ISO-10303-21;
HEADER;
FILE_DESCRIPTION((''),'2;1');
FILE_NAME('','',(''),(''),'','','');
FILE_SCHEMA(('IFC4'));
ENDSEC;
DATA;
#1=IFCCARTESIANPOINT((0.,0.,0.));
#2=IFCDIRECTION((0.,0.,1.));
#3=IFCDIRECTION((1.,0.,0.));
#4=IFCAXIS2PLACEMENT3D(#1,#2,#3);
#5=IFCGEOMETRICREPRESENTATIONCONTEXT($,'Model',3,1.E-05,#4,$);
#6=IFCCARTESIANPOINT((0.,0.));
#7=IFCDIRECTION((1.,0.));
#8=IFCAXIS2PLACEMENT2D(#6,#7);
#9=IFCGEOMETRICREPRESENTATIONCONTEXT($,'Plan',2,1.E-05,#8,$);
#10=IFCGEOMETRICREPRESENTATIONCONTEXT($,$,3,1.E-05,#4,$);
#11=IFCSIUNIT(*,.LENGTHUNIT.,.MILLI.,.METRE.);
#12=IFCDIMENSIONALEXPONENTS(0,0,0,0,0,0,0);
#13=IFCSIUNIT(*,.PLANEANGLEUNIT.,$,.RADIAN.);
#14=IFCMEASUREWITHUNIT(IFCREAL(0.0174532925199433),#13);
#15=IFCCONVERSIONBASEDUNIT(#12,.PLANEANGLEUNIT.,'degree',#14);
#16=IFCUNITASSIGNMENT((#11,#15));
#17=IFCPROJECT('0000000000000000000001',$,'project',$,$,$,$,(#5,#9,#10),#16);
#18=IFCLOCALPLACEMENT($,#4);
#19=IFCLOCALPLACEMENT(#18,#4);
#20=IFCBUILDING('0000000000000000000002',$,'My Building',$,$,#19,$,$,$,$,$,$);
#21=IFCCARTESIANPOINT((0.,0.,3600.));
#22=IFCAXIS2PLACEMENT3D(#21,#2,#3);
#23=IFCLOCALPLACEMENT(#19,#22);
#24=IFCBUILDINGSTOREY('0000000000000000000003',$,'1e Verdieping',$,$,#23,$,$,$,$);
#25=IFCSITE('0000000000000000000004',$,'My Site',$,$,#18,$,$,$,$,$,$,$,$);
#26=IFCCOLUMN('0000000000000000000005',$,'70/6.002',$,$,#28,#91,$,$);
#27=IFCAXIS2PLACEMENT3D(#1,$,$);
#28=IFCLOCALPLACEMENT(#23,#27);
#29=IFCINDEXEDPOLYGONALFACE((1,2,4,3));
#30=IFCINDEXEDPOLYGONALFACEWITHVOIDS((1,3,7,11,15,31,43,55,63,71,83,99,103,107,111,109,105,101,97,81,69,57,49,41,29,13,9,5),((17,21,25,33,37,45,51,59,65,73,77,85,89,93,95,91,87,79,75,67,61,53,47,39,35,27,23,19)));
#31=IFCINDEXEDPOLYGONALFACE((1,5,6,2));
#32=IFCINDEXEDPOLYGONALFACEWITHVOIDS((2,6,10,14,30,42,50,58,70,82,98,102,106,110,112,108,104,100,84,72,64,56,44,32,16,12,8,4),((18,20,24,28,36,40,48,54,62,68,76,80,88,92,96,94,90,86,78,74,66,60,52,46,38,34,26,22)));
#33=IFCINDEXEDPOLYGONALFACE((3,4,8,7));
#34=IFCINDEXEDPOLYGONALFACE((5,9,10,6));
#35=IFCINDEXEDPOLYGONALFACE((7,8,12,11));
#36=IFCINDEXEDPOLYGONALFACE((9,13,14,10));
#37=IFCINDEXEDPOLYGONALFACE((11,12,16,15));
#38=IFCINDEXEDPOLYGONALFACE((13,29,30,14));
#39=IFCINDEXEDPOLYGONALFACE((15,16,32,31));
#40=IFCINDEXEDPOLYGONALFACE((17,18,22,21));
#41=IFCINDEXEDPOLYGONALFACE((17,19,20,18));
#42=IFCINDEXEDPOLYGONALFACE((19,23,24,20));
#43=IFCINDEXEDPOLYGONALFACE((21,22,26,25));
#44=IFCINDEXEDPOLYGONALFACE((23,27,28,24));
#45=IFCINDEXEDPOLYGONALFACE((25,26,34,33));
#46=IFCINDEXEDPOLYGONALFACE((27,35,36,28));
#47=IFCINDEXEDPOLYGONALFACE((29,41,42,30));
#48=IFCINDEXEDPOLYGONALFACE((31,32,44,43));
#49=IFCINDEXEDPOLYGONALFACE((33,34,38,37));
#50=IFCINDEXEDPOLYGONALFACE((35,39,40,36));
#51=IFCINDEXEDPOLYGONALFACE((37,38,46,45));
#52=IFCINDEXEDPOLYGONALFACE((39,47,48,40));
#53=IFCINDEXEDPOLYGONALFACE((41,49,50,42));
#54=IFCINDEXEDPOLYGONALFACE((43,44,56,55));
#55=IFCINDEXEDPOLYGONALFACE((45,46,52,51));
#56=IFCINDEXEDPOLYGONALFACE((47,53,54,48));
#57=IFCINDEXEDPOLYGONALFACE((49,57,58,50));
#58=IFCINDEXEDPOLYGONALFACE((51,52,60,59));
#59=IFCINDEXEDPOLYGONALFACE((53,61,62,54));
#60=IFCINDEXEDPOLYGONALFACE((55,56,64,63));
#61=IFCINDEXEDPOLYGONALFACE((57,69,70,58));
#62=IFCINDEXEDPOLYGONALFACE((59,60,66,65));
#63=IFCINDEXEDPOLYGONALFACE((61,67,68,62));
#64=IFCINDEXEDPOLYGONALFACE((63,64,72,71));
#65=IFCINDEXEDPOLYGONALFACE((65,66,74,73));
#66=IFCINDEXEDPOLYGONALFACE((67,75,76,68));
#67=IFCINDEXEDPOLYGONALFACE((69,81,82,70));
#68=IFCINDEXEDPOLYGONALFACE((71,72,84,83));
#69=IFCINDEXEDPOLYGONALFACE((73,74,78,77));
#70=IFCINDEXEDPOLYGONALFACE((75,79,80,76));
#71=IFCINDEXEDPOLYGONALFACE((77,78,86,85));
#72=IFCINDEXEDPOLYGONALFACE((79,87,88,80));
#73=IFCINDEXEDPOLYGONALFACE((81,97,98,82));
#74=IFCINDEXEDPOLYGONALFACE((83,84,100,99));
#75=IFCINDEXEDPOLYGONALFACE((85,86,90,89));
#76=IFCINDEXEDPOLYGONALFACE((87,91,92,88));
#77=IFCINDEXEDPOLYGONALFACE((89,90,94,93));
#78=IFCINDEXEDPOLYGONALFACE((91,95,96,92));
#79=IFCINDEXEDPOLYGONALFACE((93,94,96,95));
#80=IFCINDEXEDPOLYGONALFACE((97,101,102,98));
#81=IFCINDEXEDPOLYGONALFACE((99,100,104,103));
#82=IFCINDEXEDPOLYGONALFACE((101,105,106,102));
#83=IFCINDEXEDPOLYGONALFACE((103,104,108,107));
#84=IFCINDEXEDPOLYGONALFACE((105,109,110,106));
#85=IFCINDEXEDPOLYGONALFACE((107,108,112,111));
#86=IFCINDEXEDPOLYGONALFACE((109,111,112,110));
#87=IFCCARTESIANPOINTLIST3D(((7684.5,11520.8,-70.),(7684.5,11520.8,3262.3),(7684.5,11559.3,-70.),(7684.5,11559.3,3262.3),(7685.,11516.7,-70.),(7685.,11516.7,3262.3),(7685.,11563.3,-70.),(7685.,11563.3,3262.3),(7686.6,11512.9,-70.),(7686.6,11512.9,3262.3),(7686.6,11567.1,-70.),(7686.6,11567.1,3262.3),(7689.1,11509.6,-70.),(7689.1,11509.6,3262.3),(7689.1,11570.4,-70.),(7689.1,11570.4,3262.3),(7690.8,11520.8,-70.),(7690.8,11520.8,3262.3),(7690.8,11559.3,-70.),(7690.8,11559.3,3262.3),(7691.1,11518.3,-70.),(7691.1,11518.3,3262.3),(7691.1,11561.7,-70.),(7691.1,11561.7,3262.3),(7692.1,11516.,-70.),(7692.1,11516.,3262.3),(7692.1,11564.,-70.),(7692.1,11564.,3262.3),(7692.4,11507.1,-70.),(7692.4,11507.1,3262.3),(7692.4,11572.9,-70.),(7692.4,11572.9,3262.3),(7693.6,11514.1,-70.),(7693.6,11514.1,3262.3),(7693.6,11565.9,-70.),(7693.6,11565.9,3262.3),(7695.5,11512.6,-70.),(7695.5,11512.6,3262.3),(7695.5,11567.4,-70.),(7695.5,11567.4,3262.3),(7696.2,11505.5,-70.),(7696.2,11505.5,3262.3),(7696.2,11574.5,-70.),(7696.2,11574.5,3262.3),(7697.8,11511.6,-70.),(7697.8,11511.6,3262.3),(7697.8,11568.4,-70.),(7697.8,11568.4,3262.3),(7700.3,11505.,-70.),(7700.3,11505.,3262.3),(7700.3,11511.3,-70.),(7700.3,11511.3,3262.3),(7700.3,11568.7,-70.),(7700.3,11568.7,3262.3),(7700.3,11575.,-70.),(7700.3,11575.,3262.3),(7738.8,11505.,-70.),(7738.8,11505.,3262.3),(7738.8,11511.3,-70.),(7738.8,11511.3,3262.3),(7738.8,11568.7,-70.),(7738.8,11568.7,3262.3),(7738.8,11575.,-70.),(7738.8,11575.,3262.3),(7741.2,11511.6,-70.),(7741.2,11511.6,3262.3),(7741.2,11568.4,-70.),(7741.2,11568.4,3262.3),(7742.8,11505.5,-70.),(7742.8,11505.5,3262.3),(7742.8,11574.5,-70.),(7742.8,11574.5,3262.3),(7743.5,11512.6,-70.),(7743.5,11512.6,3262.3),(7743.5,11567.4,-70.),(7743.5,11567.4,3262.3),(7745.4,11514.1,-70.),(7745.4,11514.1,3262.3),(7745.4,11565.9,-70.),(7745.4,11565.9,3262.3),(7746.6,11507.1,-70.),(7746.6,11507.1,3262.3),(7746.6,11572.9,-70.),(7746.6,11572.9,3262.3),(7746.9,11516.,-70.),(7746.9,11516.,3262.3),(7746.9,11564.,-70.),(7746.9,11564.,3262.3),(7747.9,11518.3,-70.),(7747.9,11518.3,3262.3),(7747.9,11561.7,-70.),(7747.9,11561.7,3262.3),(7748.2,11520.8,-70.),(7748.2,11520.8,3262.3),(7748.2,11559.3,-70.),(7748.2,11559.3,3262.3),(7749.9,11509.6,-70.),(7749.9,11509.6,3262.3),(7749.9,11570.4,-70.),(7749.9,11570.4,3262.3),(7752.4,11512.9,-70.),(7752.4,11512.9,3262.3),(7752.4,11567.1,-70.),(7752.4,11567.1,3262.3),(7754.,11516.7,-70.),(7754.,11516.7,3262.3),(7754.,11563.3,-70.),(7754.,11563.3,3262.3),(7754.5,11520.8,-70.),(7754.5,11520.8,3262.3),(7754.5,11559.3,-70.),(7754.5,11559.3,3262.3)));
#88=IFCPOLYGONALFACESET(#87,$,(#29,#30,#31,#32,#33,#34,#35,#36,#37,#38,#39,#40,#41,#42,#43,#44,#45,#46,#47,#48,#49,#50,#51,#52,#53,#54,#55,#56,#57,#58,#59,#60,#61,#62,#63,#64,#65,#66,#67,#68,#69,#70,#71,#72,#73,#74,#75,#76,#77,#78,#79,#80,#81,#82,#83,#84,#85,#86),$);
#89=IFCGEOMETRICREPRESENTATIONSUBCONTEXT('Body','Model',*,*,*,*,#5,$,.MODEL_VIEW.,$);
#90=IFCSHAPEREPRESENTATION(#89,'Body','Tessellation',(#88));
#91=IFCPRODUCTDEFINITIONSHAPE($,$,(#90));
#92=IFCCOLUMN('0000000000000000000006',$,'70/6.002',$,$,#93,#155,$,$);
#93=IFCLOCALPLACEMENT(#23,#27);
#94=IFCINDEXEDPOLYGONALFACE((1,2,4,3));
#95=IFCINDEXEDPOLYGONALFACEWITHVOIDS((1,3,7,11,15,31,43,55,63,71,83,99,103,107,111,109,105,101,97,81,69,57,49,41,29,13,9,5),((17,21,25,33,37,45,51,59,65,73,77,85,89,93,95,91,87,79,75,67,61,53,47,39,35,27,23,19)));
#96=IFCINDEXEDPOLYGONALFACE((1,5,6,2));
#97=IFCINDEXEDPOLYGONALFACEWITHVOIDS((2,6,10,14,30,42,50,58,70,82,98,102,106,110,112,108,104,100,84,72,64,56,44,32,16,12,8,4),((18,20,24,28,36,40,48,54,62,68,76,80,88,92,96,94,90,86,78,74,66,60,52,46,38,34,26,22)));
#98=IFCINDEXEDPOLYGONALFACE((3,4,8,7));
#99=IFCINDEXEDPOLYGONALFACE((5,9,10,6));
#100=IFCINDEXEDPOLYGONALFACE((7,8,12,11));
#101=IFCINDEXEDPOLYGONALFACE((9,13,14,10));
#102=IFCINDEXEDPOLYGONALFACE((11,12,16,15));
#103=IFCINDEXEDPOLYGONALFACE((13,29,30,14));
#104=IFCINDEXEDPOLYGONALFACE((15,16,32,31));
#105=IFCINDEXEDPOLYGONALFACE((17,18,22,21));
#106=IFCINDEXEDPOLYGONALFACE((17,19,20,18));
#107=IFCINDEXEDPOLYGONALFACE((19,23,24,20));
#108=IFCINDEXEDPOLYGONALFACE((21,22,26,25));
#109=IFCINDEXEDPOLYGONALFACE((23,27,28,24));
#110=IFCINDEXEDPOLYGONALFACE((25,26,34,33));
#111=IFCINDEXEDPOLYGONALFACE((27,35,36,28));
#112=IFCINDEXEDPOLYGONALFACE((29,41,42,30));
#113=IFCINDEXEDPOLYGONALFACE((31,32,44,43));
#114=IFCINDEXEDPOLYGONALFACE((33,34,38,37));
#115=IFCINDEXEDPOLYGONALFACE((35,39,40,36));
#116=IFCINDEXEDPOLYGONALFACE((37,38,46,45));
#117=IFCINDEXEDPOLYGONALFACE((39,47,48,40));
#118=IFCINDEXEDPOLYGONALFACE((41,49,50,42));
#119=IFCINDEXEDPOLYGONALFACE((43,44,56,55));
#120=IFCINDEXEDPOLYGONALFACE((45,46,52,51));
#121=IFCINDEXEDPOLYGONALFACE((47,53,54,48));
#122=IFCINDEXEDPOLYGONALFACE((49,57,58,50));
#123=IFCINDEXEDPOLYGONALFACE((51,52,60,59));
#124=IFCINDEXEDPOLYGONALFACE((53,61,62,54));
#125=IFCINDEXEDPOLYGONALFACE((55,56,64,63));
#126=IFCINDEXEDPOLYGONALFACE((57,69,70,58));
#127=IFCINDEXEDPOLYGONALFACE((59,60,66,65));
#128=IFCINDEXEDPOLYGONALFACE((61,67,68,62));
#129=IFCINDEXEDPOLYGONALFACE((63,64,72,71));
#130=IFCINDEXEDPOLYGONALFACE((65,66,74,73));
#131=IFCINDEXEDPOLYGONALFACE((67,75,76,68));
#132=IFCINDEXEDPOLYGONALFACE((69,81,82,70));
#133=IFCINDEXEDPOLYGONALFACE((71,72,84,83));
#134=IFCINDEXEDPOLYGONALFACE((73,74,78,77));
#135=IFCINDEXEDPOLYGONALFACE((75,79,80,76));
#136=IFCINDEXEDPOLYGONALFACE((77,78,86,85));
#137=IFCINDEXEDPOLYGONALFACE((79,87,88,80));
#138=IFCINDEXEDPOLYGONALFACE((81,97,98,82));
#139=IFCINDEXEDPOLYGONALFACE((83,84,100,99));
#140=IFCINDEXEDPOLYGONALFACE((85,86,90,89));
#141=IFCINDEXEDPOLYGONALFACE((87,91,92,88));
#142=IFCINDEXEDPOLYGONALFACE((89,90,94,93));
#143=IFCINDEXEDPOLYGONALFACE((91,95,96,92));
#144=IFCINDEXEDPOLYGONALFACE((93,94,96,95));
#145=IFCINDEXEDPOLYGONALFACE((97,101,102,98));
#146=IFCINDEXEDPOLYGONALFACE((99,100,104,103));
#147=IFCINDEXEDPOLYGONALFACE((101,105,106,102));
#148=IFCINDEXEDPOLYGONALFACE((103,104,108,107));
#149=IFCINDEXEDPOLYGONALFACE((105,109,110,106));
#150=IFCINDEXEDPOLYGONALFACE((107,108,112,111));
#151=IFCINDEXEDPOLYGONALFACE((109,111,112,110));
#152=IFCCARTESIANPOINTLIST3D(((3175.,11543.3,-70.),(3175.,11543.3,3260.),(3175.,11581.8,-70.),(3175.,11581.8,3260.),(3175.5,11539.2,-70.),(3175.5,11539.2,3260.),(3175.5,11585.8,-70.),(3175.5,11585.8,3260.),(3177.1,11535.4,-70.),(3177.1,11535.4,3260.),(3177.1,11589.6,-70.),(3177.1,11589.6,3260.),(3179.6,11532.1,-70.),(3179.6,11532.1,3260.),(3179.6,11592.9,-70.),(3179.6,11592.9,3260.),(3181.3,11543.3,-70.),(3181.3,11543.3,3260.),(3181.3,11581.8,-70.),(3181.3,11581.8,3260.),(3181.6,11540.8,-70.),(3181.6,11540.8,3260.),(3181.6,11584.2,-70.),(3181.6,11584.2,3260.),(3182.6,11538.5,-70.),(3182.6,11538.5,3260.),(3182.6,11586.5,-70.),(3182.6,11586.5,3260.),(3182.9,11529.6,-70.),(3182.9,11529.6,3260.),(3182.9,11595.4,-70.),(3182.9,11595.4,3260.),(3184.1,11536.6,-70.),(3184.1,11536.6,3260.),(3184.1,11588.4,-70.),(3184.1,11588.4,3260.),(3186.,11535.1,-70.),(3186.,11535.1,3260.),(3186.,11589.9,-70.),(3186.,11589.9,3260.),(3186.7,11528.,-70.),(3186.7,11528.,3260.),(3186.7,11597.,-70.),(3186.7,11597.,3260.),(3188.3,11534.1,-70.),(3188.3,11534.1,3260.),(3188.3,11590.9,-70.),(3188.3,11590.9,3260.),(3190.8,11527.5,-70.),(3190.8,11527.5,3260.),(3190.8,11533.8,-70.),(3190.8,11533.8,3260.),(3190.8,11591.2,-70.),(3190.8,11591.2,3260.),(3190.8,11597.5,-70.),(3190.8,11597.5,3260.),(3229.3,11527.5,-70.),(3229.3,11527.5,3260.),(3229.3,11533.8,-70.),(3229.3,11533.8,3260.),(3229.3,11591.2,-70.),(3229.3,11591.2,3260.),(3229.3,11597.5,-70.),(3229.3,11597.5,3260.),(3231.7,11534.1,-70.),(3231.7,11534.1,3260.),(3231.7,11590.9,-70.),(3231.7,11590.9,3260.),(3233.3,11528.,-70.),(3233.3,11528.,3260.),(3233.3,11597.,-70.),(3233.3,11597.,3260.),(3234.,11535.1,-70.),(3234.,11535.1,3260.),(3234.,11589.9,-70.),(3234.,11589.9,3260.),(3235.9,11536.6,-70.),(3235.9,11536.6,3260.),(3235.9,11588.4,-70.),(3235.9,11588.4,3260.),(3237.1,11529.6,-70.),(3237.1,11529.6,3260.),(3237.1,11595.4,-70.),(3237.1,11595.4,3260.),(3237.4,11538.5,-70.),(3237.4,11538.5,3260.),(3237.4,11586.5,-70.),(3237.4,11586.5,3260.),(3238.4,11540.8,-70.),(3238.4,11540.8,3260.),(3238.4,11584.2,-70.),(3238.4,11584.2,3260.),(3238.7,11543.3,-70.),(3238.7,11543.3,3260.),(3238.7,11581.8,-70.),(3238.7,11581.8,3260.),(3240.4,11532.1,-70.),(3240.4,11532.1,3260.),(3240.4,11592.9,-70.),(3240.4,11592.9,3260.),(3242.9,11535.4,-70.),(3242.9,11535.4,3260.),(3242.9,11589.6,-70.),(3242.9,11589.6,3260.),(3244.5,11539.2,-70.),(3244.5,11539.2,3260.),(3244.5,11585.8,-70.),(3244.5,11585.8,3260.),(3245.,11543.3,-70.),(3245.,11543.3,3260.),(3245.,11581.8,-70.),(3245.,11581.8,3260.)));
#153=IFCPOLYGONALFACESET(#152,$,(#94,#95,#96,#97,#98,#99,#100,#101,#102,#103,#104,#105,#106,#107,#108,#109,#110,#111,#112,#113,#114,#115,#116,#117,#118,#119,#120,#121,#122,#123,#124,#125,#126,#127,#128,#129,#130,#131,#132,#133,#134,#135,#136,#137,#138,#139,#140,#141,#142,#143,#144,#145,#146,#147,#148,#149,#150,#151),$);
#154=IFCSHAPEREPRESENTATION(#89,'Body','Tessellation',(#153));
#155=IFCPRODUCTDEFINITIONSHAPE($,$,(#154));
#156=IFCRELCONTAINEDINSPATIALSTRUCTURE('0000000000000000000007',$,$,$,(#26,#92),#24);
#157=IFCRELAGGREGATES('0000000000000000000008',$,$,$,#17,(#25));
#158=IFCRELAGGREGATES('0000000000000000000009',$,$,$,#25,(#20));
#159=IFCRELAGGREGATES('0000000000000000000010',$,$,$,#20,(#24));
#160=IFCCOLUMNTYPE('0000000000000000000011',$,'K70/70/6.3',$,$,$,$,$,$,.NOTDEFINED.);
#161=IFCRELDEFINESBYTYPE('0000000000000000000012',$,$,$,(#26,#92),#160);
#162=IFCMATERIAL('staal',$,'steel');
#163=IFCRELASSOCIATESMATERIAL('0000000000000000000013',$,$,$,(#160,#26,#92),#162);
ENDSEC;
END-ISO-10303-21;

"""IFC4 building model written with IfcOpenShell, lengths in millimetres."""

from ifc_helpers import new_model, entity, si_unit, converted_unit, frame, origin_with_axes, origin_2d_with_axis, place, context, subcontext, project, spatial, hollow_rectangle, extrude, material, material_profile, profile_set, profile_usage, type_object, element, save


model = new_model("IFC4")

# Units and contexts
model_context = context("Model", 3, precision=1e-05, world=origin_with_axes())
plan_context = context("Plan", 2, precision=1e-05, world=origin_2d_with_axis())
context_of_model = context(None, 3, precision=1e-05, world=origin_with_axes())
body_context = subcontext(model_context, "Body", "Model", "MODEL_VIEW")
ifc_project = project(units=[si_unit("LENGTHUNIT", "METRE", prefix="MILLI"), converted_unit("PLANEANGLEUNIT", "degree", entity("IfcReal", 0.0174532925199433), si_unit("PLANEANGLEUNIT", "RADIAN"), dimensions=[0, 0, 0, 0, 0, 0, 0])], contexts=[model_context, plan_context, context_of_model])

# Site, building, storey
site_placement = place(None, origin_with_axes())
site = spatial("IfcSite", under=ifc_project, at=site_placement, Name="My Site")
building_placement = place(site_placement, origin_with_axes())
building = spatial("IfcBuilding", under=site, at=building_placement, Name="My Building")
storey_placement = place(building_placement, frame((0.0, 0.0, 3600.0), z_axis=(0.0, 0.0, 1.0), x_axis=(1.0, 0.0, 0.0)))
storey = spatial("IfcBuildingStorey", under=building, at=storey_placement, Name="1e Verdieping")

# Columns
ifc_material_1 = material(Name="staal", Category="steel")
ifc_material_profile_1 = material_profile(ifc_material_1, hollow_rectangle(XDim=70.0, YDim=70.0, WallThickness=6.3, InnerFilletRadius=9.4, OuterFilletRadius=15.8))
ifc_profile_set_1 = profile_set([ifc_material_profile_1], Name="K70/70/6.3")
column_type_1 = type_object("IfcColumnType", Name="K70/70/6.3", PredefinedType="NOTDEFINED", material=ifc_profile_set_1)
ifc_profile_usage_1 = profile_usage(ifc_profile_set_1)
column_1_placement = place(storey_placement, frame((7719.5, 11540.0, -70.0), z_axis=(0.0, 0.0, 1.0), x_axis=(1.0, 0.0, 0.0)))
element("IfcColumn", 1, at=column_1_placement, inside=storey, type_object=column_type_1, material=ifc_profile_usage_1, Name="70/6.002", context=body_context, shape_type="SweptSolid", body=[
    extrude(hollow_rectangle(XDim=70.0, YDim=70.0, WallThickness=6.3, InnerFilletRadius=9.4, OuterFilletRadius=15.8), origin_with_axes(), (0.0, 0.0, 1.0), 3332.3),
])
ifc_profile_usage_2 = profile_usage(ifc_profile_set_1)
column_2_placement = place(storey_placement, frame((3210.0, 11562.5, -70.0), z_axis=(0.0, 0.0, 1.0), x_axis=(1.0, 0.0, 0.0)))
element("IfcColumn", 2, at=column_2_placement, inside=storey, type_object=column_type_1, material=ifc_profile_usage_2, Name="70/6.002", context=body_context, shape_type="SweptSolid", body=[
    extrude(hollow_rectangle(XDim=70.0, YDim=70.0, WallThickness=6.3, InnerFilletRadius=9.4, OuterFilletRadius=15.8), origin_with_axes(), (0.0, 0.0, 1.0), 3330.0),
])

save(model, "model.ifc")
